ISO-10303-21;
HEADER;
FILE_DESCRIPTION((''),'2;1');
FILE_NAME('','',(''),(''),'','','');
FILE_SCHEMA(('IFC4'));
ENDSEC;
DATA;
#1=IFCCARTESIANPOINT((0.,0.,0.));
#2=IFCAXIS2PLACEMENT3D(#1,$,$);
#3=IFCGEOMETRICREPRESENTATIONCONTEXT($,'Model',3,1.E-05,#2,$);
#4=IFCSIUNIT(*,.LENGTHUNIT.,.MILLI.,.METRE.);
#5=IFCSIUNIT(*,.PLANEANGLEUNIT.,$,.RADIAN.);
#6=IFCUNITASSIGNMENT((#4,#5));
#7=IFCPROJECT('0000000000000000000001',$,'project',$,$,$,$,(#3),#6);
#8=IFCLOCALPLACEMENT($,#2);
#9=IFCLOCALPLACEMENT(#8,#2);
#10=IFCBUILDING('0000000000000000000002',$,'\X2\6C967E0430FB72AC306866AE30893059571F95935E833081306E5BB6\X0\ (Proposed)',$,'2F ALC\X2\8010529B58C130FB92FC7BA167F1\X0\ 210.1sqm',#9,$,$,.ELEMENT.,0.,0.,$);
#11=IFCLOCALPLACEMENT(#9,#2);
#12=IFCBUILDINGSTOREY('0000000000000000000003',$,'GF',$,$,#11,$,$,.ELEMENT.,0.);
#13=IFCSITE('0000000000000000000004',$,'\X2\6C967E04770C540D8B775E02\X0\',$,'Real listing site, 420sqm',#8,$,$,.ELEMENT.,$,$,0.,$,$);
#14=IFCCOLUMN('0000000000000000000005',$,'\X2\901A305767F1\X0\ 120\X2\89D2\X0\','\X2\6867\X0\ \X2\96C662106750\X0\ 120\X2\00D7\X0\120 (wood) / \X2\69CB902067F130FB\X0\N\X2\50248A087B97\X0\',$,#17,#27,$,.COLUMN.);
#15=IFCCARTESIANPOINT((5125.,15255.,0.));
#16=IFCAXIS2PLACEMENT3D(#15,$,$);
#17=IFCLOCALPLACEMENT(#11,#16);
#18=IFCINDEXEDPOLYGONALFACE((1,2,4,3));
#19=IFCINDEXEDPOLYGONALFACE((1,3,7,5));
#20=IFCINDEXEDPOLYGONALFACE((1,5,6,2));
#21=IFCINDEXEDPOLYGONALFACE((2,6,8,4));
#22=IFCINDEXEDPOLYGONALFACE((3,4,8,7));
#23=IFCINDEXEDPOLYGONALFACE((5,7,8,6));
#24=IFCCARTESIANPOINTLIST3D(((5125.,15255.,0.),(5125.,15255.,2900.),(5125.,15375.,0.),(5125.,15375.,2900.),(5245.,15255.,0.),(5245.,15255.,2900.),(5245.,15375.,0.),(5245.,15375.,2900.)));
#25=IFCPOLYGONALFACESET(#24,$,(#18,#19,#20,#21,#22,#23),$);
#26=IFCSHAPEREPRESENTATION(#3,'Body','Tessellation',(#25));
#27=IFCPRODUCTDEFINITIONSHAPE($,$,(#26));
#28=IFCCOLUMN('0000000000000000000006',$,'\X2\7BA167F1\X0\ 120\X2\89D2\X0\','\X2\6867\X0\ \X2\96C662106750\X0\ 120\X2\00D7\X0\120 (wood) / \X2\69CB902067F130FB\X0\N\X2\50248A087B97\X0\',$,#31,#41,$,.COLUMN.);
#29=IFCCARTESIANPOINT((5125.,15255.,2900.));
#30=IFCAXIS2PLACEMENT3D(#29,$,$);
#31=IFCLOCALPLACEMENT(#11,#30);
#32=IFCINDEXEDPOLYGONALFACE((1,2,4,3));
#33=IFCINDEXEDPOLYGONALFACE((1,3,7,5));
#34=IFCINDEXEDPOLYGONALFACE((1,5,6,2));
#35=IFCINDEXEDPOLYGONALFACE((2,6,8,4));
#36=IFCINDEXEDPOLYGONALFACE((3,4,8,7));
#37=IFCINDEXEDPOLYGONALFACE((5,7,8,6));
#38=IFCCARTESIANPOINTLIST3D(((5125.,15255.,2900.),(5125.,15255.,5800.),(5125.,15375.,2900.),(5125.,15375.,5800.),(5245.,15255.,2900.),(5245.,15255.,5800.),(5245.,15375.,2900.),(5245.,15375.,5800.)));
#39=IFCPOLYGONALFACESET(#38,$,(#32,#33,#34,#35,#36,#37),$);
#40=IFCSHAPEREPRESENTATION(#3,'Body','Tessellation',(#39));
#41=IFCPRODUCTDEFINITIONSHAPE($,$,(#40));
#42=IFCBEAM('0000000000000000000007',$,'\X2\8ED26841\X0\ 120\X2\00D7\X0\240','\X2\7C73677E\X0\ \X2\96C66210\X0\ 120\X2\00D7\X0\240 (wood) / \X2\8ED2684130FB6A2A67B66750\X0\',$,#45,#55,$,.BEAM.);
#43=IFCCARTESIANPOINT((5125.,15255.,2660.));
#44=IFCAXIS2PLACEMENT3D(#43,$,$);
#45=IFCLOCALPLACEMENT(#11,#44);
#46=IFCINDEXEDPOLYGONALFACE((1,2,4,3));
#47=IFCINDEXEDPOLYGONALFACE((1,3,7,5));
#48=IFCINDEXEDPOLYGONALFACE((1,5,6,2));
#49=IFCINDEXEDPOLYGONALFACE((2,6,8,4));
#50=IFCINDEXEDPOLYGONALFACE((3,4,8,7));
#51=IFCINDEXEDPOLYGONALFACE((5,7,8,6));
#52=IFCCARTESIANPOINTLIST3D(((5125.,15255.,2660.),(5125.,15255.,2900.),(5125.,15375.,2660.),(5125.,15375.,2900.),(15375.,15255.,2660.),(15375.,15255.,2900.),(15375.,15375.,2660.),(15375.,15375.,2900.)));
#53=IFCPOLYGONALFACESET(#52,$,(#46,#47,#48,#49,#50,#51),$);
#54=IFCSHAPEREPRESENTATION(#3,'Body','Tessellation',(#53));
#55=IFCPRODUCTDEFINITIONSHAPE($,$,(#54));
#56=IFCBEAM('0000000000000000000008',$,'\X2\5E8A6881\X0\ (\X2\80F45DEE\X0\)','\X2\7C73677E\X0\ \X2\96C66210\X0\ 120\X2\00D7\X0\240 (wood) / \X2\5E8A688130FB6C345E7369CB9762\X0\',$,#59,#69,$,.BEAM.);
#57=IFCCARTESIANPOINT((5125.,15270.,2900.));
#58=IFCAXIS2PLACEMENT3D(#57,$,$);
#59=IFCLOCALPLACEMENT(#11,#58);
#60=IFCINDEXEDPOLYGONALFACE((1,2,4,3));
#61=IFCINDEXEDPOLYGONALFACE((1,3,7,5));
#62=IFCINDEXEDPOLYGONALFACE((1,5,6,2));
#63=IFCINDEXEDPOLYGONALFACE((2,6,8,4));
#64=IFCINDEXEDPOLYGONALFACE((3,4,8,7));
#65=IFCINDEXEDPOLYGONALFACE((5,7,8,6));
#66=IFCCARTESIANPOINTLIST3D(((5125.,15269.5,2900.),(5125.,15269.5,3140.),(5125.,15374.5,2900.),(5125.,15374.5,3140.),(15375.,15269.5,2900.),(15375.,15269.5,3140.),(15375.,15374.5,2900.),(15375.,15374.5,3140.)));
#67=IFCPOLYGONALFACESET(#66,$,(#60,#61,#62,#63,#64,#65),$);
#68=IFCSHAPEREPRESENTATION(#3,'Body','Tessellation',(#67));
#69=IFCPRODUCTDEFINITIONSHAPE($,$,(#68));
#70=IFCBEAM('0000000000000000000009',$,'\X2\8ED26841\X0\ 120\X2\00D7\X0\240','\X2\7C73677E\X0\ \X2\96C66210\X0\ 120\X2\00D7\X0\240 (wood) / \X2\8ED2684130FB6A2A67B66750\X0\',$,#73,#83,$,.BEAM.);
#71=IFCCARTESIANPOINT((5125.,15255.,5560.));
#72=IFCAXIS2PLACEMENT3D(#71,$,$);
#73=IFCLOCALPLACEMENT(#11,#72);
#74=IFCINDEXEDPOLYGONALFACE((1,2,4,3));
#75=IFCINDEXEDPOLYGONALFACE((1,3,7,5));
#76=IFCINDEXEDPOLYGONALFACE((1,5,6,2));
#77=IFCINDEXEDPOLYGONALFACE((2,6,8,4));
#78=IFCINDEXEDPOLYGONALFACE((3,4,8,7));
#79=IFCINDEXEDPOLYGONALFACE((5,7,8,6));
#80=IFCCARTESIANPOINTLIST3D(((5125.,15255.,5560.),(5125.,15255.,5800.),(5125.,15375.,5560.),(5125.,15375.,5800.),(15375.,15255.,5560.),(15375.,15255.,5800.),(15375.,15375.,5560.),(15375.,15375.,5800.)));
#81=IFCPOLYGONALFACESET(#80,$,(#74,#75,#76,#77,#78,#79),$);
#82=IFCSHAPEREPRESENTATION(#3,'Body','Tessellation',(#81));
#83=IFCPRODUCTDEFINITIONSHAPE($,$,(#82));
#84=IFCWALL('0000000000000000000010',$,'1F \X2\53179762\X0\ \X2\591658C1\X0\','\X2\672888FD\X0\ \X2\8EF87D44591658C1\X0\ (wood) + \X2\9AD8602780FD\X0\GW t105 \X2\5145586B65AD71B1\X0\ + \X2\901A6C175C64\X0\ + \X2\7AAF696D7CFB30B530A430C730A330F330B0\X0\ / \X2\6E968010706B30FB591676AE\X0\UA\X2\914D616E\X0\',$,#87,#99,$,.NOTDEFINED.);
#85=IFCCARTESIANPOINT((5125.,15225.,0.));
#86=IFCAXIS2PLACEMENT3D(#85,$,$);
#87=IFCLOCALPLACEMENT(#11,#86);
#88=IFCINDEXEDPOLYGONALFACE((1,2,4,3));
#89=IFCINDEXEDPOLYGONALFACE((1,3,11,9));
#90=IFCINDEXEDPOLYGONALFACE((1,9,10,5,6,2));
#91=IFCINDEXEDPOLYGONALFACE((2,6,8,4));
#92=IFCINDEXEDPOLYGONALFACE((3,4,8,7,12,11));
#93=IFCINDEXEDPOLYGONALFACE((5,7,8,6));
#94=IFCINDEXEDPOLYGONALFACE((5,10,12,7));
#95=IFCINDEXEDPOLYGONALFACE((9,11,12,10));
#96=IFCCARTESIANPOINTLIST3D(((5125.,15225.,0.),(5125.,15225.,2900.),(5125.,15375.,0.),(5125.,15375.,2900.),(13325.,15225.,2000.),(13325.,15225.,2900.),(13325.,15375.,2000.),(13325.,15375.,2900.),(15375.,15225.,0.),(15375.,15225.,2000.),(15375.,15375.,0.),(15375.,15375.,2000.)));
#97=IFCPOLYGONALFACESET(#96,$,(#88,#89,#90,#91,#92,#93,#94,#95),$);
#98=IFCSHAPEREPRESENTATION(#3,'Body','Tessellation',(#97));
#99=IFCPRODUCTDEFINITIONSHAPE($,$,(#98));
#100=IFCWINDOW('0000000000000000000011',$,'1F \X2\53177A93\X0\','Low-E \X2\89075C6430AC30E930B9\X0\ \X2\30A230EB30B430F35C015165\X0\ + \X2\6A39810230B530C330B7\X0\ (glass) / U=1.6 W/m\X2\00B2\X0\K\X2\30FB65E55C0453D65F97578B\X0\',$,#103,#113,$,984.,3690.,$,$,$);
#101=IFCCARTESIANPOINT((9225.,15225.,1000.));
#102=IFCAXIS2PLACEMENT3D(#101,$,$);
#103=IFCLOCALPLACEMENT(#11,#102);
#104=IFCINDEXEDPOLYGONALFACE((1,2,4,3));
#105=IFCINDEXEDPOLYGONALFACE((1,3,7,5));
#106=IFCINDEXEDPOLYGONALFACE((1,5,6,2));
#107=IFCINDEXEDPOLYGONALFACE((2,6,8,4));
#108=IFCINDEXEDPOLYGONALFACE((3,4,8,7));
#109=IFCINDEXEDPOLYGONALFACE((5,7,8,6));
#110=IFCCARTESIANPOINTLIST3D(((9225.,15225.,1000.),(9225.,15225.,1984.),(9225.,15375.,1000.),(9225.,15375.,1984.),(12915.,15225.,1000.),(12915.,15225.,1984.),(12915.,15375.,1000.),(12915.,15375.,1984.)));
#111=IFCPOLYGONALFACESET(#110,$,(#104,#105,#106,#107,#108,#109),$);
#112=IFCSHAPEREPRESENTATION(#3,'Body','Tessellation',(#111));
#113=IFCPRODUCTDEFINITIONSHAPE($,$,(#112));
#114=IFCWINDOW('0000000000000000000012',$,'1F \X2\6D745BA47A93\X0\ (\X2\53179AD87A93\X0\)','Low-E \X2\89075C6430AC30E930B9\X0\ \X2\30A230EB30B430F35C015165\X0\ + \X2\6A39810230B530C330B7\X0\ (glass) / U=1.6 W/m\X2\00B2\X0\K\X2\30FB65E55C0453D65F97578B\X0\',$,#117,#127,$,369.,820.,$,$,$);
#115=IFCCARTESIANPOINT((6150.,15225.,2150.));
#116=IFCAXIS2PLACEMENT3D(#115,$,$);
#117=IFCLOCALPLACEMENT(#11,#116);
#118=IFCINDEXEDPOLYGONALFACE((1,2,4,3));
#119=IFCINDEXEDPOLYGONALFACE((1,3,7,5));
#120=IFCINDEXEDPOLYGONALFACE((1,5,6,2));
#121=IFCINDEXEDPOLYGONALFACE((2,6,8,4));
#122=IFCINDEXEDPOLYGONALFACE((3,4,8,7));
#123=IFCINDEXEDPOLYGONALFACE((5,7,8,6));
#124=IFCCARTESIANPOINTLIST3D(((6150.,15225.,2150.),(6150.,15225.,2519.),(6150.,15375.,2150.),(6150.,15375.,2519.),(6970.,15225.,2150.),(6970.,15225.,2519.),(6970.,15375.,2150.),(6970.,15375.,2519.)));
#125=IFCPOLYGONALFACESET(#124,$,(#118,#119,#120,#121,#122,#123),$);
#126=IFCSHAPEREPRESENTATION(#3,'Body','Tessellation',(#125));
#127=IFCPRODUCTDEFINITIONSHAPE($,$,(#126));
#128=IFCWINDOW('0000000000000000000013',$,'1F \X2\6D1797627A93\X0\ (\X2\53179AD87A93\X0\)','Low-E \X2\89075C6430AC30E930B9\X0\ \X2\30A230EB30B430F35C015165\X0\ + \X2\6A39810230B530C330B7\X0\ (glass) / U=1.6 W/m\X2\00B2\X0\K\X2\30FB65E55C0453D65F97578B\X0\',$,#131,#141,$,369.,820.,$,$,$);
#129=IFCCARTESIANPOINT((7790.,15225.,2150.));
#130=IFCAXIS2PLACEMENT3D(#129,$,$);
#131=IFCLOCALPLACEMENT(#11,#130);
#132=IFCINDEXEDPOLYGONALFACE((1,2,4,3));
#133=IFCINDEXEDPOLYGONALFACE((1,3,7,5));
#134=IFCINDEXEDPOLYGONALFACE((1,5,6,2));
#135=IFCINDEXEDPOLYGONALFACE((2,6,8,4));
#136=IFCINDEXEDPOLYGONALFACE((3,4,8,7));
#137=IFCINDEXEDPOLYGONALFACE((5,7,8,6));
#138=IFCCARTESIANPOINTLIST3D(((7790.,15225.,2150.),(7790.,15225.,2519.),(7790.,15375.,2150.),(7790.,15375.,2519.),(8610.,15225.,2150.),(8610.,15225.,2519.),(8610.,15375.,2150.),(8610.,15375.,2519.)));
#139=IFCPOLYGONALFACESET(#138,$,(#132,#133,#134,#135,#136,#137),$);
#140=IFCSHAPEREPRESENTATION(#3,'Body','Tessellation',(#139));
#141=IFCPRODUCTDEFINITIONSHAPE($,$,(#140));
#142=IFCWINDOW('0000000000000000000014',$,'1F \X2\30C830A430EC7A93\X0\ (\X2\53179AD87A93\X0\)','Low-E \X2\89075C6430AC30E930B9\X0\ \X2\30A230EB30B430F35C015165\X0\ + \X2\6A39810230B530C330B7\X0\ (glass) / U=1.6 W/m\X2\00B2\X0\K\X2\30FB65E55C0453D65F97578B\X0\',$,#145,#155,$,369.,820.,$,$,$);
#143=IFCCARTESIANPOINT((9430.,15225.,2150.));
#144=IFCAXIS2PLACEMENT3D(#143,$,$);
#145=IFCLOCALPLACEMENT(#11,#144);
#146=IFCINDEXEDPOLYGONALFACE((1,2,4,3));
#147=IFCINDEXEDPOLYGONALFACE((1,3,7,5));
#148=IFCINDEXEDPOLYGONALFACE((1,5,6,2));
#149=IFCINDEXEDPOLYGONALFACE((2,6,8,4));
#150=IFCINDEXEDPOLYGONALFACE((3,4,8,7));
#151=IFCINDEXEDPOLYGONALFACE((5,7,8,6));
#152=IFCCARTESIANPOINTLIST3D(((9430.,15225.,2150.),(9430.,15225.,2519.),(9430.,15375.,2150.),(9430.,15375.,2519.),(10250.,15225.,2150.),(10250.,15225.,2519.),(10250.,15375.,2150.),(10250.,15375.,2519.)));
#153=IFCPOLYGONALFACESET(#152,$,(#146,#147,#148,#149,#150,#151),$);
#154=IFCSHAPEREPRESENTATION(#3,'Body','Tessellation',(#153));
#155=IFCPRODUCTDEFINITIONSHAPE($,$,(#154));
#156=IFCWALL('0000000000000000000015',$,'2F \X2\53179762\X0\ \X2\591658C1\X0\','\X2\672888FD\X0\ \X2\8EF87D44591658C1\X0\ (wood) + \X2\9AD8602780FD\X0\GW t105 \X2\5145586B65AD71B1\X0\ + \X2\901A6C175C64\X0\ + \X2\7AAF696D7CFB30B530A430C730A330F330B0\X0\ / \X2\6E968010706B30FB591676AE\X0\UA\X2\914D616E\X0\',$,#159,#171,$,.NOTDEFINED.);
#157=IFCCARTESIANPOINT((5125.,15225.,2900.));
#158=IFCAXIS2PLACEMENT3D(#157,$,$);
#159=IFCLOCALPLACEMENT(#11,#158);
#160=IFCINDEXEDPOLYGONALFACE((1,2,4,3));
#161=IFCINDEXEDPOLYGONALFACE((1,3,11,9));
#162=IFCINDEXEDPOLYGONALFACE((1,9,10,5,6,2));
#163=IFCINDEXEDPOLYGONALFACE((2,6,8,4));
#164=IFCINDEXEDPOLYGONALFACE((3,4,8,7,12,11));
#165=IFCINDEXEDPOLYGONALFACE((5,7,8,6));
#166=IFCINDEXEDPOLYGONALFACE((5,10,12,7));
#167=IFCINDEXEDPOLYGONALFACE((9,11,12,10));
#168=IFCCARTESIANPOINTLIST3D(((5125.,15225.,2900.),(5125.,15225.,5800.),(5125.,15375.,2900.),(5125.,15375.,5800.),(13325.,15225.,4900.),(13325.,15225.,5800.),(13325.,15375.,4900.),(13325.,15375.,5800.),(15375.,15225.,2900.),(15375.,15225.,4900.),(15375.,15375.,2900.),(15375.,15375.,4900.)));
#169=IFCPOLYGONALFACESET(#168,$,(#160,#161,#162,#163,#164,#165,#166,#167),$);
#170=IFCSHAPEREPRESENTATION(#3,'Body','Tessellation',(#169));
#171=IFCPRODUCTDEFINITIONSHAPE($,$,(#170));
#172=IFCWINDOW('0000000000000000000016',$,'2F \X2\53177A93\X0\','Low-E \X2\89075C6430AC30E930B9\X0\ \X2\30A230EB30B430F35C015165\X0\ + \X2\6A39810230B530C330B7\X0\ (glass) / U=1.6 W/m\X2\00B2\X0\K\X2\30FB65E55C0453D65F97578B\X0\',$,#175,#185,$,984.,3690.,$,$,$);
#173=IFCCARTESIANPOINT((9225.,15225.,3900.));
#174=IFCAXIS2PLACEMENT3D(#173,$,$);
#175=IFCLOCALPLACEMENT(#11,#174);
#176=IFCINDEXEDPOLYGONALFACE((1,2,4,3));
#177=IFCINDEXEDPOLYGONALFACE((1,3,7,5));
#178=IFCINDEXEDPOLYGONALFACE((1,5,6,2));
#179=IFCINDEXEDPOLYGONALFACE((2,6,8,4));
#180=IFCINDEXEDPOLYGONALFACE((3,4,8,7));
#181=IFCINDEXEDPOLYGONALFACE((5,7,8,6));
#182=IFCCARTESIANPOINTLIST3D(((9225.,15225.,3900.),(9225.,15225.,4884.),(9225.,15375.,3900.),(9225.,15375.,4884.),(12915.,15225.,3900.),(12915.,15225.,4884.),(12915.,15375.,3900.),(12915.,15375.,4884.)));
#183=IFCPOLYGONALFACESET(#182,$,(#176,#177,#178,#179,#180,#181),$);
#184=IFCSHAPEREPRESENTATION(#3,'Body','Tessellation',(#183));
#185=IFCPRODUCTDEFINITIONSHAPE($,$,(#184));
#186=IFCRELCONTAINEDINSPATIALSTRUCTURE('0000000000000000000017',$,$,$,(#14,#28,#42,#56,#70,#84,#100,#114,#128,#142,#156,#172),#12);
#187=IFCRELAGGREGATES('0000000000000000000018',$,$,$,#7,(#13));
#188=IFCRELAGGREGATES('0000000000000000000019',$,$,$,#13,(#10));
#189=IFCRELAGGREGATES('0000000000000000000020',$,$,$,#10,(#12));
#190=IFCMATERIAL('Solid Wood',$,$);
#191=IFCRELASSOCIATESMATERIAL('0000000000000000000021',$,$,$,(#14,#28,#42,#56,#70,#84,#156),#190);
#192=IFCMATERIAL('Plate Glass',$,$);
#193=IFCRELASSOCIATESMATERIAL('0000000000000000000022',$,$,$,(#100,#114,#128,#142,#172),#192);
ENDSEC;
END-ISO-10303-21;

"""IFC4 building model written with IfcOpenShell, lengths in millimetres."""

from ifc_helpers import new_model, si_unit, frame, frame_2d, origin, place, context, project, spatial, rectangle, extrude, material, element, fill, save


model = new_model("IFC4")

# Units and contexts
model_context = context("Model", 3, precision=1e-05, world=origin())
ifc_project = project(units=[si_unit("LENGTHUNIT", "METRE", prefix="MILLI"), si_unit("PLANEANGLEUNIT", "RADIAN")], contexts=[model_context])

# Site, building, storey
site_placement = place(None, origin())
site = spatial("IfcSite", under=ifc_project, at=site_placement, Name="沖縄県名護市", ObjectType="Real listing site, 420sqm", CompositionType="ELEMENT", RefElevation=0.0)
building_placement = place(site_placement, origin())
building = spatial("IfcBuilding", under=site, at=building_placement, Name="沖縄・犬と暮らす土間広めの家 (Proposed)", ObjectType="2F ALC耐力壁・鋼管柱 210.1sqm", CompositionType="ELEMENT", ElevationOfRefHeight=0.0, ElevationOfTerrain=0.0)
storey_placement = place(building_placement, origin())
storey = spatial("IfcBuildingStorey", under=building, at=storey_placement, Name="GF", CompositionType="ELEMENT", Elevation=0.0)

# Columns
ifc_material_1 = material(Name="Solid Wood")
column_1_placement = place(storey_placement, frame((5125.0, 15255.0, 0.0)))
element("IfcColumn", 1, at=column_1_placement, inside=storey, material=ifc_material_1, Name="通し柱 120角", Description="桧 集成材 120×120 (wood) / 構造柱・N値計算", PredefinedType="COLUMN", context=model_context, shape_type="SweptSolid", body=[
    extrude(rectangle(XDim=120.0, YDim=120.0, at=frame_2d((60.0, 60.0))), frame((5125.0, 15255.0, 0.0)), (0.0, 0.0, 1.0), 2900.0),
])
column_2_placement = place(storey_placement, frame((5125.0, 15255.0, 2900.0)))
element("IfcColumn", 2, at=column_2_placement, inside=storey, material=ifc_material_1, Name="管柱 120角", Description="桧 集成材 120×120 (wood) / 構造柱・N値計算", PredefinedType="COLUMN", context=model_context, shape_type="SweptSolid", body=[
    extrude(rectangle(XDim=120.0, YDim=120.0, at=frame_2d((60.0, 60.0))), frame((5125.0, 15255.0, 2900.0)), (0.0, 0.0, 1.0), 2900.0),
])

# Beams
beam_1_placement = place(storey_placement, frame((5125.0, 15255.0, 2660.0)))
element("IfcBeam", 3, at=beam_1_placement, inside=storey, material=ifc_material_1, Name="軒桁 120×240", Description="米松 集成 120×240 (wood) / 軒桁・横架材", PredefinedType="BEAM", context=model_context, shape_type="SweptSolid", body=[
    extrude(rectangle(XDim=10250.0, YDim=120.0, at=frame_2d((5125.0, 60.0))), frame((5125.0, 15255.0, 2660.0)), (0.0, 0.0, 1.0), 240.0),
])
beam_2_placement = place(storey_placement, frame((5125.0, 15270.0, 2900.0)))
element("IfcBeam", 4, at=beam_2_placement, inside=storey, material=ifc_material_1, Name="床梁 (胴差)", Description="米松 集成 120×240 (wood) / 床梁・水平構面", PredefinedType="BEAM", context=model_context, shape_type="SweptSolid", body=[
    extrude(rectangle(XDim=10250.0, YDim=105.0, at=frame_2d((5125.0, 52.0))), frame((5125.0, 15270.0, 2900.0)), (0.0, 0.0, 1.0), 240.0),
])
beam_3_placement = place(storey_placement, frame((5125.0, 15255.0, 5560.0)))
element("IfcBeam", 5, at=beam_3_placement, inside=storey, material=ifc_material_1, Name="軒桁 120×240", Description="米松 集成 120×240 (wood) / 軒桁・横架材", PredefinedType="BEAM", context=model_context, shape_type="SweptSolid", body=[
    extrude(rectangle(XDim=10250.0, YDim=120.0, at=frame_2d((5125.0, 60.0))), frame((5125.0, 15255.0, 5560.0)), (0.0, 0.0, 1.0), 240.0),
])

# Wall, openings, windows
wall_1_placement = place(storey_placement, frame((5125.0, 15225.0, 0.0)))
wall_1 = element("IfcWall", 6, at=wall_1_placement, inside=storey, material=ifc_material_1, Name="1F 北面 外壁", Description="木製 軸組外壁 (wood) + 高性能GW t105 充填断熱 + 通気層 + 窯業系サイディング / 準耐火・外皮UA配慮", PredefinedType="NOTDEFINED", context=model_context, shape_type="SweptSolid", body=[
    extrude(rectangle(XDim=10250.0, YDim=150.0, at=frame_2d((5125.0, 75.0))), frame((5125.0, 15225.0, 0.0)), (0.0, 0.0, 1.0), 2900.0),
])
opening_1_placement = place(storey_placement, frame((9225.0, 15225.0, 1000.0)))
opening_1 = element("IfcOpeningElement", 7, at=opening_1_placement, cuts=wall_1, PredefinedType="NOTDEFINED", context=model_context, shape_type="SweptSolid", body=[
    extrude(rectangle(XDim=3690.0, YDim=150.0, at=frame_2d((1845.0, 75.0))), frame((9225.0, 15225.0, 1000.0)), (0.0, 0.0, 1.0), 984.0),
])
opening_2_placement = place(storey_placement, frame((6150.0, 15225.0, 2150.0)))
opening_2 = element("IfcOpeningElement", 8, at=opening_2_placement, cuts=wall_1, PredefinedType="NOTDEFINED", context=model_context, shape_type="SweptSolid", body=[
    extrude(rectangle(XDim=820.0, YDim=150.0, at=frame_2d((410.0, 75.0))), frame((6150.0, 15225.0, 2150.0)), (0.0, 0.0, 1.0), 369.0),
])
opening_3_placement = place(storey_placement, frame((7790.0, 15225.0, 2150.0)))
opening_3 = element("IfcOpeningElement", 9, at=opening_3_placement, cuts=wall_1, PredefinedType="NOTDEFINED", context=model_context, shape_type="SweptSolid", body=[
    extrude(rectangle(XDim=820.0, YDim=150.0, at=frame_2d((410.0, 75.0))), frame((7790.0, 15225.0, 2150.0)), (0.0, 0.0, 1.0), 369.0),
])
opening_4_placement = place(storey_placement, frame((9430.0, 15225.0, 2150.0)))
opening_4 = element("IfcOpeningElement", 10, at=opening_4_placement, cuts=wall_1, PredefinedType="NOTDEFINED", context=model_context, shape_type="SweptSolid", body=[
    extrude(rectangle(XDim=820.0, YDim=150.0, at=frame_2d((410.0, 75.0))), frame((9430.0, 15225.0, 2150.0)), (0.0, 0.0, 1.0), 369.0),
])
ifc_material_2 = material(Name="Plate Glass")
window_1_placement = place(storey_placement, frame((9225.0, 15225.0, 1000.0)))
window_1 = element("IfcWindow", 11, at=window_1_placement, inside=storey, material=ifc_material_2, Name="1F 北窓", Description="Low-E 複層ガラス アルゴン封入 + 樹脂サッシ (glass) / U=1.6 W/m²K・日射取得型", OverallHeight=984.0, OverallWidth=3690.0, context=model_context, shape_type="SweptSolid", body=[
    extrude(rectangle(XDim=3690.0, YDim=150.0, at=frame_2d((1845.0, 75.0))), frame((9225.0, 15225.0, 1000.0)), (0.0, 0.0, 1.0), 984.0),
])
fill(opening_1, window_1)
window_2_placement = place(storey_placement, frame((6150.0, 15225.0, 2150.0)))
window_2 = element("IfcWindow", 12, at=window_2_placement, inside=storey, material=ifc_material_2, Name="1F 浴室窓 (北高窓)", Description="Low-E 複層ガラス アルゴン封入 + 樹脂サッシ (glass) / U=1.6 W/m²K・日射取得型", OverallHeight=369.0, OverallWidth=820.0, context=model_context, shape_type="SweptSolid", body=[
    extrude(rectangle(XDim=820.0, YDim=150.0, at=frame_2d((410.0, 75.0))), frame((6150.0, 15225.0, 2150.0)), (0.0, 0.0, 1.0), 369.0),
])
fill(opening_2, window_2)
window_3_placement = place(storey_placement, frame((7790.0, 15225.0, 2150.0)))
window_3 = element("IfcWindow", 13, at=window_3_placement, inside=storey, material=ifc_material_2, Name="1F 洗面窓 (北高窓)", Description="Low-E 複層ガラス アルゴン封入 + 樹脂サッシ (glass) / U=1.6 W/m²K・日射取得型", OverallHeight=369.0, OverallWidth=820.0, context=model_context, shape_type="SweptSolid", body=[
    extrude(rectangle(XDim=820.0, YDim=150.0, at=frame_2d((410.0, 75.0))), frame((7790.0, 15225.0, 2150.0)), (0.0, 0.0, 1.0), 369.0),
])
fill(opening_3, window_3)
window_4_placement = place(storey_placement, frame((9430.0, 15225.0, 2150.0)))
window_4 = element("IfcWindow", 14, at=window_4_placement, inside=storey, material=ifc_material_2, Name="1F トイレ窓 (北高窓)", Description="Low-E 複層ガラス アルゴン封入 + 樹脂サッシ (glass) / U=1.6 W/m²K・日射取得型", OverallHeight=369.0, OverallWidth=820.0, context=model_context, shape_type="SweptSolid", body=[
    extrude(rectangle(XDim=820.0, YDim=150.0, at=frame_2d((410.0, 75.0))), frame((9430.0, 15225.0, 2150.0)), (0.0, 0.0, 1.0), 369.0),
])
fill(opening_4, window_4)

# Wall, opening, window
wall_2_placement = place(storey_placement, frame((5125.0, 15225.0, 2900.0)))
wall_2 = element("IfcWall", 15, at=wall_2_placement, inside=storey, material=ifc_material_1, Name="2F 北面 外壁", Description="木製 軸組外壁 (wood) + 高性能GW t105 充填断熱 + 通気層 + 窯業系サイディング / 準耐火・外皮UA配慮", PredefinedType="NOTDEFINED", context=model_context, shape_type="SweptSolid", body=[
    extrude(rectangle(XDim=10250.0, YDim=150.0, at=frame_2d((5125.0, 75.0))), frame((5125.0, 15225.0, 2900.0)), (0.0, 0.0, 1.0), 2900.0),
])
opening_5_placement = place(storey_placement, frame((9225.0, 15225.0, 3900.0)))
opening_5 = element("IfcOpeningElement", 16, at=opening_5_placement, cuts=wall_2, PredefinedType="NOTDEFINED", context=model_context, shape_type="SweptSolid", body=[
    extrude(rectangle(XDim=3690.0, YDim=150.0, at=frame_2d((1845.0, 75.0))), frame((9225.0, 15225.0, 3900.0)), (0.0, 0.0, 1.0), 984.0),
])
window_5_placement = place(storey_placement, frame((9225.0, 15225.0, 3900.0)))
window_5 = element("IfcWindow", 17, at=window_5_placement, inside=storey, material=ifc_material_2, Name="2F 北窓", Description="Low-E 複層ガラス アルゴン封入 + 樹脂サッシ (glass) / U=1.6 W/m²K・日射取得型", OverallHeight=984.0, OverallWidth=3690.0, context=model_context, shape_type="SweptSolid", body=[
    extrude(rectangle(XDim=3690.0, YDim=150.0, at=frame_2d((1845.0, 75.0))), frame((9225.0, 15225.0, 3900.0)), (0.0, 0.0, 1.0), 984.0),
])
fill(opening_5, window_5)

save(model, "model.ifc")
